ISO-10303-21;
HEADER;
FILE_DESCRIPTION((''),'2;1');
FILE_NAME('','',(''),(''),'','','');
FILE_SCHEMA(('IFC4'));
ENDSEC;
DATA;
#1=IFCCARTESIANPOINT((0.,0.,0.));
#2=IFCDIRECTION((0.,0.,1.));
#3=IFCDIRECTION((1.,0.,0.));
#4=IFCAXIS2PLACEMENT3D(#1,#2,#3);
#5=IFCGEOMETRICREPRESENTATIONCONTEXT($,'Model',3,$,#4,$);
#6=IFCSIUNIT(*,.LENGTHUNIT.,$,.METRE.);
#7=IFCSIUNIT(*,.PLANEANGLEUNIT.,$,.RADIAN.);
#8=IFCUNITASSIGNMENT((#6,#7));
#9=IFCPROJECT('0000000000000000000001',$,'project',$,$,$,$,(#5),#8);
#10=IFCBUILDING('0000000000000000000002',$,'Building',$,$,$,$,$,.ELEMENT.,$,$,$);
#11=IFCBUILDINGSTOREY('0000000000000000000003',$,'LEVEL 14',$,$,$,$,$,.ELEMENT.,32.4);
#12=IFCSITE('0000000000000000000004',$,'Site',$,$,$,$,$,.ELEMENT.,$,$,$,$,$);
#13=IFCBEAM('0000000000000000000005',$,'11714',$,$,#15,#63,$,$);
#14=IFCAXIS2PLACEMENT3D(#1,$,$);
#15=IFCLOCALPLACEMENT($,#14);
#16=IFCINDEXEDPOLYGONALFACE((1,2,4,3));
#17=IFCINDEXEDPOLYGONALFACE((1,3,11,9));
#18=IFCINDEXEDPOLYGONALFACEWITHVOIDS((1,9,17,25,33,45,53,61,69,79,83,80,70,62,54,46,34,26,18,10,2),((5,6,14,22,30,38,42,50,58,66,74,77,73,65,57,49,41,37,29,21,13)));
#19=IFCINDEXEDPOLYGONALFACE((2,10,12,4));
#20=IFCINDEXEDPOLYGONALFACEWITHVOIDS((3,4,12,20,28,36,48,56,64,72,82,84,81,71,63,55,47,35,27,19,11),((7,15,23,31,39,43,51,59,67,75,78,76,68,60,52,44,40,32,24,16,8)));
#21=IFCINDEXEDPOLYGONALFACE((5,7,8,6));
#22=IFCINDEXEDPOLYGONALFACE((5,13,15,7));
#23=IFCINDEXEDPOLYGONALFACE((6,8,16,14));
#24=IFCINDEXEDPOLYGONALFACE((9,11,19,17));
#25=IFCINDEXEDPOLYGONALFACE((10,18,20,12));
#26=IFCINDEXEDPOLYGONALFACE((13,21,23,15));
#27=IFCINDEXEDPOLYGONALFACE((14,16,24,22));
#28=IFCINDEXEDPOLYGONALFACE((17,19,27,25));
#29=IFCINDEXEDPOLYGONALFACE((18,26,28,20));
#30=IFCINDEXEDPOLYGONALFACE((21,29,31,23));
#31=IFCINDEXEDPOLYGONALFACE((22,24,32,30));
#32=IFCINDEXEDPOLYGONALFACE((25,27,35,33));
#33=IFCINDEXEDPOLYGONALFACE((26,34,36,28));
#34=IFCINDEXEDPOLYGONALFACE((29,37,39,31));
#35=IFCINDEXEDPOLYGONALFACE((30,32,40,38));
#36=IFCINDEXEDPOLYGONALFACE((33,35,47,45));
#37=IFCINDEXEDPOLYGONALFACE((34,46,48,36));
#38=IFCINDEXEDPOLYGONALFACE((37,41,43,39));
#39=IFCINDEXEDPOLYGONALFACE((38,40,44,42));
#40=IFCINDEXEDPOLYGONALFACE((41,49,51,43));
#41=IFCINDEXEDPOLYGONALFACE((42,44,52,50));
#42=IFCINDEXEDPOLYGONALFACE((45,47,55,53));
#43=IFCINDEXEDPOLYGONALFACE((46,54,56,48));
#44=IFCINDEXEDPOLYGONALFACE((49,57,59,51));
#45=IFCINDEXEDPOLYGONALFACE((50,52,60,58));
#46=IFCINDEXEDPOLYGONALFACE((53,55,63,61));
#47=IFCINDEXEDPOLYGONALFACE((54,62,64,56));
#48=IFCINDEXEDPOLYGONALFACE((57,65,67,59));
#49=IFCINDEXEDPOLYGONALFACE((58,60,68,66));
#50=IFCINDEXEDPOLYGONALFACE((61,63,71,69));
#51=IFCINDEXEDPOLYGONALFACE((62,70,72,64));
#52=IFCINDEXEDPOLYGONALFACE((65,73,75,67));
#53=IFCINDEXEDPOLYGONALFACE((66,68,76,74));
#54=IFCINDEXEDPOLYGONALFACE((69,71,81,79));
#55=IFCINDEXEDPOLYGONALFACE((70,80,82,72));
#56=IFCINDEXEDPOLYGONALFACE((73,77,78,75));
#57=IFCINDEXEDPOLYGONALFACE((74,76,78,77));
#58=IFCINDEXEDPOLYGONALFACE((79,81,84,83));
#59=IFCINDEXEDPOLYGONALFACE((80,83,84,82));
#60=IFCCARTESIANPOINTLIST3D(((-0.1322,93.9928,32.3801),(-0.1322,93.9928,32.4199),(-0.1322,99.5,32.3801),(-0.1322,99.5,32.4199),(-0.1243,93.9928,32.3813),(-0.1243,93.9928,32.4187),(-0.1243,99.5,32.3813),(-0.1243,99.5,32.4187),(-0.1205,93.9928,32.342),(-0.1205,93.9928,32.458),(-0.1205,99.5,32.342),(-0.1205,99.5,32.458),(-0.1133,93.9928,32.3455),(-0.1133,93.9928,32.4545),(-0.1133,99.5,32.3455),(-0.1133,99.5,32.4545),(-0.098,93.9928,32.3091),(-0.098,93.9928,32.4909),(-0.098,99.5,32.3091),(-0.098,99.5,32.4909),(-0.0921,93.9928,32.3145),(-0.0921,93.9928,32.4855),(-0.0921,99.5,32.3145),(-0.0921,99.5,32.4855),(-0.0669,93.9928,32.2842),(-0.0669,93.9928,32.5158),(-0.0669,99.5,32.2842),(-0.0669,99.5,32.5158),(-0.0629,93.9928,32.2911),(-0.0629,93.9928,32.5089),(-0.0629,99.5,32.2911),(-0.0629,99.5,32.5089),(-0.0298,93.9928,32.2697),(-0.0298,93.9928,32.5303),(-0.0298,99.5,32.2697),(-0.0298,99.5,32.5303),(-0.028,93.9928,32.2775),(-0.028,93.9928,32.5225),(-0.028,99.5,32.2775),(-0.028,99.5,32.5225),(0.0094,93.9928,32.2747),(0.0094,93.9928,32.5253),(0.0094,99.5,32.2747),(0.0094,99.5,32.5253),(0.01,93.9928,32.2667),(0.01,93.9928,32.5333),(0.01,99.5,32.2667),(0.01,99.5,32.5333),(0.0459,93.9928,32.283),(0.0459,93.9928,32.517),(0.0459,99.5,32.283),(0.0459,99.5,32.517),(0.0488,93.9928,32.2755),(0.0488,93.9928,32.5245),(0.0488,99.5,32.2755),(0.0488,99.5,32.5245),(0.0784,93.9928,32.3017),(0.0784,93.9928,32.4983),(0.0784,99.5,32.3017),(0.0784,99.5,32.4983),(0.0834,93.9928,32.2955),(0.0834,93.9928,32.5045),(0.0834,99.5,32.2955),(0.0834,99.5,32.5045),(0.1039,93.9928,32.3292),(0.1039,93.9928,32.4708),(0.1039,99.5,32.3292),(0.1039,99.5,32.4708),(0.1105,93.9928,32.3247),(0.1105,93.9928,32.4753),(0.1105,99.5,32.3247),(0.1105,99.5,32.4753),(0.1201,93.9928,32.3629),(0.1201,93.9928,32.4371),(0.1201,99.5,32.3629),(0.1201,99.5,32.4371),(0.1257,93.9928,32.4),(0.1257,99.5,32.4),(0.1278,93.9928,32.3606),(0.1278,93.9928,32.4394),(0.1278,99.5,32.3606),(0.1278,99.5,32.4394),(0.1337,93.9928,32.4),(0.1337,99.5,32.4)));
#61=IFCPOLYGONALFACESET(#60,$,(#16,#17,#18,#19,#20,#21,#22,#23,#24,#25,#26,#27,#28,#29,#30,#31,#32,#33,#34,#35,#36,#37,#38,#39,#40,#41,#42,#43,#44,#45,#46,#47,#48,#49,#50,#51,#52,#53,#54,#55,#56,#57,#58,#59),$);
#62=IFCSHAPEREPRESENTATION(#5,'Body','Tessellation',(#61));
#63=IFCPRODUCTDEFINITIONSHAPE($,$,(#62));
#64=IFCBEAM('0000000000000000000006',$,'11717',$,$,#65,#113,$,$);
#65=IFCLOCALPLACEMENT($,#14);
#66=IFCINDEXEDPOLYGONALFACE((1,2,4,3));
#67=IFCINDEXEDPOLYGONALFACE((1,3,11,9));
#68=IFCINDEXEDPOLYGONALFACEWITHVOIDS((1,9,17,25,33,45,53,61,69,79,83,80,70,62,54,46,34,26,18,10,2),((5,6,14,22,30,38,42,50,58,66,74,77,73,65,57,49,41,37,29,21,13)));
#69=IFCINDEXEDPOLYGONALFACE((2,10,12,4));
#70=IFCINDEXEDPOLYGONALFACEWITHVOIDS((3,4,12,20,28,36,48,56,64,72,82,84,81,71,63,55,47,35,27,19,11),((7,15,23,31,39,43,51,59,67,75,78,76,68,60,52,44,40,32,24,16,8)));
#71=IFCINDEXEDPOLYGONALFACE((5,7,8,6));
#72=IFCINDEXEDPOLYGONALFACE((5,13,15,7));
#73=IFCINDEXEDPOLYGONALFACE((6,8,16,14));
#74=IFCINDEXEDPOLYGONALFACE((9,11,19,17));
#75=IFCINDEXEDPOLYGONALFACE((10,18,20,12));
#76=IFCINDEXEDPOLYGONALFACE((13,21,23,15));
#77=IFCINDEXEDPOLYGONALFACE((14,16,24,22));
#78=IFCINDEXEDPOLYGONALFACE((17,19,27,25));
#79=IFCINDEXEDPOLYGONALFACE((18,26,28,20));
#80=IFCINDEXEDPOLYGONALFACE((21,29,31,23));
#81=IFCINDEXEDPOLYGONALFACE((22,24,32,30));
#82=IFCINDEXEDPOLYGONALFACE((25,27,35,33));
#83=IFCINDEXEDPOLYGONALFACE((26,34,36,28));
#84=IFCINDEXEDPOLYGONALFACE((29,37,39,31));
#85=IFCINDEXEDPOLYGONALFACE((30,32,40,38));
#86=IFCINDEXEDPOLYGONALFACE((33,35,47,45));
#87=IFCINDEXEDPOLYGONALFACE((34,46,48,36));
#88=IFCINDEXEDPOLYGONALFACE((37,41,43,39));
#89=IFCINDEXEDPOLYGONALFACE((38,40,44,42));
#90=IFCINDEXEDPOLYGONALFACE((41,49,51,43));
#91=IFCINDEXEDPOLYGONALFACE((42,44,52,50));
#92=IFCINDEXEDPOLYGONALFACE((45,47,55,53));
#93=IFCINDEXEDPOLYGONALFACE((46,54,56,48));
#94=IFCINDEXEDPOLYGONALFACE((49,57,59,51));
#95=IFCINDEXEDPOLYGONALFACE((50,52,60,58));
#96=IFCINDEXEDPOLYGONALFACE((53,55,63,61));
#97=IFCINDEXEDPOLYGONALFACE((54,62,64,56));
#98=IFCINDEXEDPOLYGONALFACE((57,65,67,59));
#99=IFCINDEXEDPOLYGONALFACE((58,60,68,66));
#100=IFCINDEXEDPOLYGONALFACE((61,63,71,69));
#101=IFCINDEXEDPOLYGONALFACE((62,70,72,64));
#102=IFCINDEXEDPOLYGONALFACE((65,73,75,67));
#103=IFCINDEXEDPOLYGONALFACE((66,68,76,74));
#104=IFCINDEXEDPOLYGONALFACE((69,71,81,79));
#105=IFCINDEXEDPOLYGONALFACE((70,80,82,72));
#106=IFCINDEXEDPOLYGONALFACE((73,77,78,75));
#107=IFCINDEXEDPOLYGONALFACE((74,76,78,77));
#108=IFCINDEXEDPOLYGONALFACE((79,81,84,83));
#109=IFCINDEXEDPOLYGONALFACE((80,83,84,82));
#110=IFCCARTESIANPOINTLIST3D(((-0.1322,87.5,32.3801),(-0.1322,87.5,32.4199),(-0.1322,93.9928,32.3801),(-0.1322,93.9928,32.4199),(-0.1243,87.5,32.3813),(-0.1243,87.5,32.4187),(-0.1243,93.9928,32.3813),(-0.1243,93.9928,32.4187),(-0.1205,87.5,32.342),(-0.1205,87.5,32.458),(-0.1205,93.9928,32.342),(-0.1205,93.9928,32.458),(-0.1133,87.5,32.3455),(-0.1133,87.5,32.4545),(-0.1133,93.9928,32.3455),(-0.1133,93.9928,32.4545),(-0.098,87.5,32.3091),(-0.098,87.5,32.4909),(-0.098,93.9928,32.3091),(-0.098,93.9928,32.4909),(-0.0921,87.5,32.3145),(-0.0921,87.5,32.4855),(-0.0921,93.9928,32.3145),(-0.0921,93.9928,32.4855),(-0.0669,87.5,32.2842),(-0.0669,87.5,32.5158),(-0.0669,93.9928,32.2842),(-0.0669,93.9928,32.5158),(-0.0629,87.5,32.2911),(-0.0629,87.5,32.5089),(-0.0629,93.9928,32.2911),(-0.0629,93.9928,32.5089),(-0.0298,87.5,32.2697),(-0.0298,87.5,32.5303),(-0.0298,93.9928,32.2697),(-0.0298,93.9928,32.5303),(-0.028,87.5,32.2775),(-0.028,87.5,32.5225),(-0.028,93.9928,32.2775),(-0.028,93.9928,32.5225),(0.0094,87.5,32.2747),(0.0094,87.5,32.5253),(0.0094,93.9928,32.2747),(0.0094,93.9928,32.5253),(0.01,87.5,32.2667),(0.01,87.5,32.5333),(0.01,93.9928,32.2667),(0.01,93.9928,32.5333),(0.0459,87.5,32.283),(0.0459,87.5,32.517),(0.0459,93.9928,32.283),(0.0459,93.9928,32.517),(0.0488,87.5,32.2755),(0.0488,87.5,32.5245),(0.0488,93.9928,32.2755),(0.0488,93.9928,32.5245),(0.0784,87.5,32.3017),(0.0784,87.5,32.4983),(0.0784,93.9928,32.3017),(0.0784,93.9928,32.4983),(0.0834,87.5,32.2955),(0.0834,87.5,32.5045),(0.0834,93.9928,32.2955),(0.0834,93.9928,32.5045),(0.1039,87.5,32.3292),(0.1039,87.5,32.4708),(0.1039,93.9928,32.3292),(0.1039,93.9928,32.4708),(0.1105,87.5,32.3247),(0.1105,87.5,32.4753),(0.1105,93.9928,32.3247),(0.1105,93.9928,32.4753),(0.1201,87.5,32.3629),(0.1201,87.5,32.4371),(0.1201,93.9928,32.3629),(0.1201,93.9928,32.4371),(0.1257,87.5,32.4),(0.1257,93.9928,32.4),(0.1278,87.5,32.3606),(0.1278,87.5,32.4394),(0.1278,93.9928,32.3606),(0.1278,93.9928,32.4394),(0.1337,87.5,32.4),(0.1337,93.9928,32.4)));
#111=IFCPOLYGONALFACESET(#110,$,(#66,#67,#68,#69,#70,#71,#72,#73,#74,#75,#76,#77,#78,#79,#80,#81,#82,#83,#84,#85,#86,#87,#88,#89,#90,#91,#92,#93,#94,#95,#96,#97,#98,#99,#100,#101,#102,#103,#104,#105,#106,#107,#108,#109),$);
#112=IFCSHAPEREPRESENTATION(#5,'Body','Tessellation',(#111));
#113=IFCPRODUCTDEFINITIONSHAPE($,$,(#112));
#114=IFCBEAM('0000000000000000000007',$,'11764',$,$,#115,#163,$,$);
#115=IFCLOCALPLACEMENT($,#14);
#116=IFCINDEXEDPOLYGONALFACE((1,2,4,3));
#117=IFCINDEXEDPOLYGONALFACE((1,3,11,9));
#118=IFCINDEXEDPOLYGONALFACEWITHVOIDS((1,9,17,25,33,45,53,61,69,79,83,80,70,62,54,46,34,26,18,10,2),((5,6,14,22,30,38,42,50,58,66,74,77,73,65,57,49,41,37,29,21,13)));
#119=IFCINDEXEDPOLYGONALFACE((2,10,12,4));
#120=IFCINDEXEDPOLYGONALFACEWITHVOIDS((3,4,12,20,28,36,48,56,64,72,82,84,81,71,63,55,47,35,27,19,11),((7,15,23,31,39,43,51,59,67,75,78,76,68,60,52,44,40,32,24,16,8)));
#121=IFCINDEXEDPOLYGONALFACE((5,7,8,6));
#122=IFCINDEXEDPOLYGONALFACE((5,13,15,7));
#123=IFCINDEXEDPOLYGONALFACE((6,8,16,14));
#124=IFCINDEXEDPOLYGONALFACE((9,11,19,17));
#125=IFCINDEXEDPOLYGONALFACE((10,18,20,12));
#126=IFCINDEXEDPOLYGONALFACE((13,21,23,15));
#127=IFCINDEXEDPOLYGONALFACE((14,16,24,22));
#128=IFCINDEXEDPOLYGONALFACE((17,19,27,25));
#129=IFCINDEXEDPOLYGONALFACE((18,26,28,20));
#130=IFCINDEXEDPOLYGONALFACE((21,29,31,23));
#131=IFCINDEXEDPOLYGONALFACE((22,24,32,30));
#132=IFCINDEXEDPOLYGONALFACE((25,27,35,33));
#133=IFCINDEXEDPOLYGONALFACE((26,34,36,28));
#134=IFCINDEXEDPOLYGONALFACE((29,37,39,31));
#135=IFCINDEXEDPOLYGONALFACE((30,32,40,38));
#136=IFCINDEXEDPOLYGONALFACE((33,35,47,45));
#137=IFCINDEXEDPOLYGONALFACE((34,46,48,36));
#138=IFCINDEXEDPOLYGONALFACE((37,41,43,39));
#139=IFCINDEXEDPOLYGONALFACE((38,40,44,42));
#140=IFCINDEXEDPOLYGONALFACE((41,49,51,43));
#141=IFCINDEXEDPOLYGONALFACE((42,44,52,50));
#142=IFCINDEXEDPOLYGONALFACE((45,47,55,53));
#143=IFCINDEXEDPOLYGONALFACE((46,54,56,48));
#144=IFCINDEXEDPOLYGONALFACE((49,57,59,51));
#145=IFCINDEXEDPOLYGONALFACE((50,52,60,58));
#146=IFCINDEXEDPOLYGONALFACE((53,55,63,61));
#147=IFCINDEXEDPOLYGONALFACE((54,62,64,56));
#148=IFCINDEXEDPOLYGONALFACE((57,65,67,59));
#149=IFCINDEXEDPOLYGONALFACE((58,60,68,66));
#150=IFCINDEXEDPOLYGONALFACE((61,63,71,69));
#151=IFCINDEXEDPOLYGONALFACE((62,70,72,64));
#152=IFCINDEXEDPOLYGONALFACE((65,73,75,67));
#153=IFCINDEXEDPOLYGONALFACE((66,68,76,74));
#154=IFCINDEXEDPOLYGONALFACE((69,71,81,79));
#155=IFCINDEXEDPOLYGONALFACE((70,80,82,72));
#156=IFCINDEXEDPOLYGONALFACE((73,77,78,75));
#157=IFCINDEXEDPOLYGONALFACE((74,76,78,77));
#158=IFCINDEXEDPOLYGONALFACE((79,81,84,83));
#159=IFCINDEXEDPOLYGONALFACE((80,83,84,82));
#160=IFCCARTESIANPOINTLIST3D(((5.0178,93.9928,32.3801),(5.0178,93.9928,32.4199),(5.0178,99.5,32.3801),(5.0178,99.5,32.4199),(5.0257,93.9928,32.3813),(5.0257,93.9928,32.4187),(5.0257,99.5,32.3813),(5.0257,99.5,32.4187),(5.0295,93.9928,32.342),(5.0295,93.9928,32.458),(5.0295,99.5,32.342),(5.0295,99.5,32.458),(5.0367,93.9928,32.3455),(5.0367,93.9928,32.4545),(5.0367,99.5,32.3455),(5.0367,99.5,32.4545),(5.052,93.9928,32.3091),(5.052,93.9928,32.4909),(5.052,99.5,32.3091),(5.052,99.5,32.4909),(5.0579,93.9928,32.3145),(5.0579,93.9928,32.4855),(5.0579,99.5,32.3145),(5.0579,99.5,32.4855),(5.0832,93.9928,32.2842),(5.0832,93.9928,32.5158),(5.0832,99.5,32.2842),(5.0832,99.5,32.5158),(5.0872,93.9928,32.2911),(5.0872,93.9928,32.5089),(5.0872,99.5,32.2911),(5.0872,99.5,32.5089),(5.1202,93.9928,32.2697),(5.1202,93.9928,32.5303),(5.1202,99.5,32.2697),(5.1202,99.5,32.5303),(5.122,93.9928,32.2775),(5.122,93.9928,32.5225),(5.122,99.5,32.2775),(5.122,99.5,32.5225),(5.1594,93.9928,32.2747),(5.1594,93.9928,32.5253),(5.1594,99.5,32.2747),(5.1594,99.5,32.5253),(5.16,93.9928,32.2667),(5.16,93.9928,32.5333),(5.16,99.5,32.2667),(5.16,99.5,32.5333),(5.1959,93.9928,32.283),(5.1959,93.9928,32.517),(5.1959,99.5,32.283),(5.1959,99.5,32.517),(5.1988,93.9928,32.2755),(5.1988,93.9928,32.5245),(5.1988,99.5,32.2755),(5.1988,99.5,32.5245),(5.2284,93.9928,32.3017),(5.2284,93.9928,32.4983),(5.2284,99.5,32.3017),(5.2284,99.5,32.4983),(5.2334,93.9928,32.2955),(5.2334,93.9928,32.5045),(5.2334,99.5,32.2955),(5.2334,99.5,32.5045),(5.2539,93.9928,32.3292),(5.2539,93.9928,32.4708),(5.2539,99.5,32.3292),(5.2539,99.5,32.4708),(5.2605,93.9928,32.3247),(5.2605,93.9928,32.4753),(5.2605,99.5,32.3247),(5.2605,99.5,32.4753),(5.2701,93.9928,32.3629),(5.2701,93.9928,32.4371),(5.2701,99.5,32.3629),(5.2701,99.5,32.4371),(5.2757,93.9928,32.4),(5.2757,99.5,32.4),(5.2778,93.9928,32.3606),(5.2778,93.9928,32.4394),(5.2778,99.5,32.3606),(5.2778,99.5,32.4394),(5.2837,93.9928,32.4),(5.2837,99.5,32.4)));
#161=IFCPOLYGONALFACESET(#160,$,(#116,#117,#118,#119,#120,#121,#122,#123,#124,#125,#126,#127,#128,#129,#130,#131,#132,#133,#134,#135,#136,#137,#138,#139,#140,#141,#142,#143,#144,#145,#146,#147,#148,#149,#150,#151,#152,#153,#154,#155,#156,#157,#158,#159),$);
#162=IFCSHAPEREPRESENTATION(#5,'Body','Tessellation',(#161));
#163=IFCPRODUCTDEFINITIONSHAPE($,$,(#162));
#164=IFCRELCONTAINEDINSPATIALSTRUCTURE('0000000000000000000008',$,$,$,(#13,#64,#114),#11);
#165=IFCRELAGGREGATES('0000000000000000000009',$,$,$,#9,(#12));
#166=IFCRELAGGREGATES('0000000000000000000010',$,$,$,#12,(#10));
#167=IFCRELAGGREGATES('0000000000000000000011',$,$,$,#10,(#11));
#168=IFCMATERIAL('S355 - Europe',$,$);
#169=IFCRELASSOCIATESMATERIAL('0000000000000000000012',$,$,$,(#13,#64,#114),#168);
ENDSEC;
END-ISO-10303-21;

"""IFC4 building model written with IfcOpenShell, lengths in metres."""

from ifc_helpers import new_model, si_unit, frame, origin_with_axes, origin_2d_with_axis, place, context, project, spatial, hollow_circle, extrude, material, material_profile, profile_set, profile_usage, element, save


model = new_model("IFC4")

# Units and contexts
model_context = context("Model", 3, world=origin_with_axes())
ifc_project = project(units=[si_unit("LENGTHUNIT", "METRE"), si_unit("PLANEANGLEUNIT", "RADIAN")], contexts=[model_context])

# Site, building, storey
site = spatial("IfcSite", under=ifc_project, Name="Site", CompositionType="ELEMENT")
building = spatial("IfcBuilding", under=site, Name="Building", CompositionType="ELEMENT")
storey = spatial("IfcBuildingStorey", under=building, Name="LEVEL 14", CompositionType="ELEMENT", Elevation=32.4)

# Shared definitions
ifc_material = material(Name="S355 - Europe")

# Beams
ifc_material_profile_1 = material_profile(ifc_material, hollow_circle(Radius=0.1337, WallThickness=0.008, at=origin_2d_with_axis()))
ifc_profile_set_1 = profile_set([ifc_material_profile_1])
ifc_profile_usage_1 = profile_usage(ifc_profile_set_1, cardinal=10)
beam_1_placement = place(None, frame((0.0, 99.5, 32.4), z_axis=(0.0, -1.0, 0.0), x_axis=(1.0, 0.0, 0.0)))
element("IfcBeam", 1, at=beam_1_placement, inside=storey, material=ifc_profile_usage_1, Name="11714", context=model_context, shape_type="SweptSolid", body=[
    extrude(hollow_circle(Radius=0.1337, WallThickness=0.008, at=origin_2d_with_axis()), origin_with_axes(), (0.0, 0.0, 1.0), 5.5072),
])
ifc_material_profile_2 = material_profile(ifc_material, hollow_circle(Radius=0.1337, WallThickness=0.008, at=origin_2d_with_axis()))
ifc_profile_set_2 = profile_set([ifc_material_profile_2])
ifc_profile_usage_2 = profile_usage(ifc_profile_set_2, cardinal=10)
beam_2_placement = place(None, frame((0.0, 93.9928, 32.4), z_axis=(0.0, -1.0, 0.0), x_axis=(1.0, 0.0, 0.0)))
element("IfcBeam", 2, at=beam_2_placement, inside=storey, material=ifc_profile_usage_2, Name="11717", context=model_context, shape_type="SweptSolid", body=[
    extrude(hollow_circle(Radius=0.1337, WallThickness=0.008, at=origin_2d_with_axis()), origin_with_axes(), (0.0, 0.0, 1.0), 6.4928),
])
ifc_material_profile_3 = material_profile(ifc_material, hollow_circle(Radius=0.1337, WallThickness=0.008, at=origin_2d_with_axis()))
ifc_profile_set_3 = profile_set([ifc_material_profile_3])
ifc_profile_usage_3 = profile_usage(ifc_profile_set_3, cardinal=10)
beam_3_placement = place(None, frame((5.15, 99.5, 32.4), z_axis=(0.0, -1.0, 0.0), x_axis=(1.0, 0.0, 0.0)))
element("IfcBeam", 3, at=beam_3_placement, inside=storey, material=ifc_profile_usage_3, Name="11764", context=model_context, shape_type="SweptSolid", body=[
    extrude(hollow_circle(Radius=0.1337, WallThickness=0.008, at=origin_2d_with_axis()), origin_with_axes(), (0.0, 0.0, 1.0), 5.5072),
])

save(model, "model.ifc")
